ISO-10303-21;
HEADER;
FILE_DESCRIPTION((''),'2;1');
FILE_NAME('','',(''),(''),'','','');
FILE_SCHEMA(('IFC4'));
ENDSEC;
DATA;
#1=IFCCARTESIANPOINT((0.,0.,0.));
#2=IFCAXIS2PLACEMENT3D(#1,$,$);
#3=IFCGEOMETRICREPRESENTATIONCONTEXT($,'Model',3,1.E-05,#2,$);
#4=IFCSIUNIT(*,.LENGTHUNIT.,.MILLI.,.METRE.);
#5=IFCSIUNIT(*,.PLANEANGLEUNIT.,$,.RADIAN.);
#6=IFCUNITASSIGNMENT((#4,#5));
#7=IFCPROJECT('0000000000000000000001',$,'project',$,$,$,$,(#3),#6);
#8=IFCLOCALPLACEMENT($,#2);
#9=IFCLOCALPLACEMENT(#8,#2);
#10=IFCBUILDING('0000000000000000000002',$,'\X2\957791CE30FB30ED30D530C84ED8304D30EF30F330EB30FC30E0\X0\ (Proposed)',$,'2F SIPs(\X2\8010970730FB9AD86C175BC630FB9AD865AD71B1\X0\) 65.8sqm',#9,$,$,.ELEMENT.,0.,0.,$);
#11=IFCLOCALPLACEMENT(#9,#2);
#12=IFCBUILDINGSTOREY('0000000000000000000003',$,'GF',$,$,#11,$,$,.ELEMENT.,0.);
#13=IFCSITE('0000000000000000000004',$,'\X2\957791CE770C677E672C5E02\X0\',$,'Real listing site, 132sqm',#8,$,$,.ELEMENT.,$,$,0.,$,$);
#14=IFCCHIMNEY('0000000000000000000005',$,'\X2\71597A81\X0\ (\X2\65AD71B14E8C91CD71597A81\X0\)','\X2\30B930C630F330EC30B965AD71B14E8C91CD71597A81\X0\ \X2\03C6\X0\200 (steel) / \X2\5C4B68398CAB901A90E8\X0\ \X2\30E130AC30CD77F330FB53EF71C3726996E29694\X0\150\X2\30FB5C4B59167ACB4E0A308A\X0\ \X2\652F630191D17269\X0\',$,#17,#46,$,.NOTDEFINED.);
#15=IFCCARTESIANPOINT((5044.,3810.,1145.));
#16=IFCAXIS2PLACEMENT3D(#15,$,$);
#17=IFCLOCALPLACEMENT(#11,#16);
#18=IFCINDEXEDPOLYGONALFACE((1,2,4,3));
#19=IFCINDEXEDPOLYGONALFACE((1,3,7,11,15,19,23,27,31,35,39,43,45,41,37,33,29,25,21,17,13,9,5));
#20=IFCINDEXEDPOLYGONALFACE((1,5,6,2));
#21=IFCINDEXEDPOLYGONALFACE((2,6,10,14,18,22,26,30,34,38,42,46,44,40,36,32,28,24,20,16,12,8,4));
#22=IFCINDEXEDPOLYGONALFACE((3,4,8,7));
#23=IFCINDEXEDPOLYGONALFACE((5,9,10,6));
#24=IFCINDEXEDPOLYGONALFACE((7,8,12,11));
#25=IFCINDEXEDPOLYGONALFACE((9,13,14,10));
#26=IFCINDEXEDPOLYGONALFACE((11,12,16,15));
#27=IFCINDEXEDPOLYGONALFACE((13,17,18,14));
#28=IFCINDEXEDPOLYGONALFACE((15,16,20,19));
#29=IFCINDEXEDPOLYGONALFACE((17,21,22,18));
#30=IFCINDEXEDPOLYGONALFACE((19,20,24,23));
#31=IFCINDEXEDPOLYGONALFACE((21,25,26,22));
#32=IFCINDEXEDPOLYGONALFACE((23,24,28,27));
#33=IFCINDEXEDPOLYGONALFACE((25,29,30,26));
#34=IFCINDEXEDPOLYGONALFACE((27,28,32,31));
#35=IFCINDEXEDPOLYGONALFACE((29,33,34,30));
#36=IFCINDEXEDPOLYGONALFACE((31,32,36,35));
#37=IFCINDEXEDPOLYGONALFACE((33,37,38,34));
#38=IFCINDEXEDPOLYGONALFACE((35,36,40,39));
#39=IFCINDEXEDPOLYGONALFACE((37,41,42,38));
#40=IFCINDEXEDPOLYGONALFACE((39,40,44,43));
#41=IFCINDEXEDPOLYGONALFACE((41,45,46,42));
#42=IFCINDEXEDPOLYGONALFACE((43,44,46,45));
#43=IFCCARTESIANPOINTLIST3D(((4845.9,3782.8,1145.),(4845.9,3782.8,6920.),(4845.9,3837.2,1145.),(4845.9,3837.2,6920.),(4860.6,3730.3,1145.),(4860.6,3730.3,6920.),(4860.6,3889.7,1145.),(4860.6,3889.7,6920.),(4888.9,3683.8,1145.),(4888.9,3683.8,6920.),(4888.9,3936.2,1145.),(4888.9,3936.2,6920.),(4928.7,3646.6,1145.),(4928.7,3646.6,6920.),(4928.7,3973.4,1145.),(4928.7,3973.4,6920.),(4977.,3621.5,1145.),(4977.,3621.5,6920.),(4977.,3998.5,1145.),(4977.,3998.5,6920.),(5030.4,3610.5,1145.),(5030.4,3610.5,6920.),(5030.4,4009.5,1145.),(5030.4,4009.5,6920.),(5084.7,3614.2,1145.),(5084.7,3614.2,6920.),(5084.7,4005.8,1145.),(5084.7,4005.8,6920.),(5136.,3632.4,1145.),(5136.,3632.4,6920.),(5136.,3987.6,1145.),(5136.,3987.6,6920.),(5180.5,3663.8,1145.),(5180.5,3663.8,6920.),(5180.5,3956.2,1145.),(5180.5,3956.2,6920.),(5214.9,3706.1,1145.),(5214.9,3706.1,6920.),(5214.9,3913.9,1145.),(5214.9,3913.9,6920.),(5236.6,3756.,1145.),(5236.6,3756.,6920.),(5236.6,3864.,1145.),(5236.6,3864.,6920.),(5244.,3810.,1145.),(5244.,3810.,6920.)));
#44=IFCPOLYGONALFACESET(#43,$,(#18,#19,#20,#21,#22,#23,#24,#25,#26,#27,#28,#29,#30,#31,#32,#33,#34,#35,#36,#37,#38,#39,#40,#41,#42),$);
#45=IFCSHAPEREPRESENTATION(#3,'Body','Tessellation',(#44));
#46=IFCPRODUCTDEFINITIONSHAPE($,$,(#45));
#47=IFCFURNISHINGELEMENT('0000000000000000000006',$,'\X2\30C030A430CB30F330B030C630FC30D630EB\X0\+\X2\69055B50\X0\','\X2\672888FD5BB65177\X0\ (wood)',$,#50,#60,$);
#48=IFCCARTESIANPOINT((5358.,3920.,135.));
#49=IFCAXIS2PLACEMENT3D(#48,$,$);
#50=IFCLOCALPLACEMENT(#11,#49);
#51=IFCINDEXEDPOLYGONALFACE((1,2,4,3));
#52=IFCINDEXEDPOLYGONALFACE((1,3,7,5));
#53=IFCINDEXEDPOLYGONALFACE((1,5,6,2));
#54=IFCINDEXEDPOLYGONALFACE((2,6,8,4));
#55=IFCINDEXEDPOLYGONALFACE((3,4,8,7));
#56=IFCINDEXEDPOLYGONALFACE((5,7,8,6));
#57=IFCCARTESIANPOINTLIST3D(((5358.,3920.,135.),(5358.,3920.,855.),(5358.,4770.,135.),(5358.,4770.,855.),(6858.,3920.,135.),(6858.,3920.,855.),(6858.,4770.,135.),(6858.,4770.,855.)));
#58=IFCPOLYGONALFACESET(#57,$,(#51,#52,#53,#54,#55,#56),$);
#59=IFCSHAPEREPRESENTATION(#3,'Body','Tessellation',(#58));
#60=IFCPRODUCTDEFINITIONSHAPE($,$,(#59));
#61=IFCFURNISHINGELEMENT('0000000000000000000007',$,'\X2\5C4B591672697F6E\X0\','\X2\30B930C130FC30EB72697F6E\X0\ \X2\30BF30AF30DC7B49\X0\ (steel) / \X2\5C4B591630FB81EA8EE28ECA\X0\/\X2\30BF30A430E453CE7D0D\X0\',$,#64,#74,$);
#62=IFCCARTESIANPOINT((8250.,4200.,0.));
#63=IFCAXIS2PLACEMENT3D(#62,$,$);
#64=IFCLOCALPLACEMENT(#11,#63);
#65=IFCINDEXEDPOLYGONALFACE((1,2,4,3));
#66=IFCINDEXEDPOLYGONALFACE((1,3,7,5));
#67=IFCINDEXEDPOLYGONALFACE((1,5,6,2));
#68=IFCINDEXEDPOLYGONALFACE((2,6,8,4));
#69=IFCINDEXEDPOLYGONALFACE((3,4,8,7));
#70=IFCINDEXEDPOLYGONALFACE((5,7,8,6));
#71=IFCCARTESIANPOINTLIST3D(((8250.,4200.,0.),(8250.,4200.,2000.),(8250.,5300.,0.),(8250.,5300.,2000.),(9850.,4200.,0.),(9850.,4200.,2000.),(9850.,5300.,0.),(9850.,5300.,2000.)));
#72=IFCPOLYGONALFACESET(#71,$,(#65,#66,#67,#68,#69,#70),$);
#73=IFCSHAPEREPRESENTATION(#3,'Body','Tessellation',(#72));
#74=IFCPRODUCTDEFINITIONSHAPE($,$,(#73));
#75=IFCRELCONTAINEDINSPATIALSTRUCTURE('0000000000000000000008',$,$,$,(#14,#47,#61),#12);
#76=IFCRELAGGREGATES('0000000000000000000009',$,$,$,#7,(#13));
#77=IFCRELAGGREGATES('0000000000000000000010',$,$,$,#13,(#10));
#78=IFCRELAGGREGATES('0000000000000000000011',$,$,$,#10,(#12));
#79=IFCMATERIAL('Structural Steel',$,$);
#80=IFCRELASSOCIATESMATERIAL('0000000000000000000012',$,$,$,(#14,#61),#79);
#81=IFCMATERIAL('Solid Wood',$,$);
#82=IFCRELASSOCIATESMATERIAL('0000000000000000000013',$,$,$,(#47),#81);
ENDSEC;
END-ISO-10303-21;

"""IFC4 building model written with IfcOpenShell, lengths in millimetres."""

from ifc_helpers import new_model, si_unit, frame, frame_2d, origin, origin_2d, place, context, project, spatial, rectangle, circle, extrude, material, element, save


model = new_model("IFC4")

# Units and contexts
model_context = context("Model", 3, precision=1e-05, world=origin())
ifc_project = project(units=[si_unit("LENGTHUNIT", "METRE", prefix="MILLI"), si_unit("PLANEANGLEUNIT", "RADIAN")], contexts=[model_context])

# Site, building, storey
site_placement = place(None, origin())
site = spatial("IfcSite", under=ifc_project, at=site_placement, Name="長野県松本市", ObjectType="Real listing site, 132sqm", CompositionType="ELEMENT", RefElevation=0.0)
building_placement = place(site_placement, origin())
building = spatial("IfcBuilding", under=site, at=building_placement, Name="長野・ロフト付きワンルーム (Proposed)", ObjectType="2F SIPs(耐震・高気密・高断熱) 65.8sqm", CompositionType="ELEMENT", ElevationOfRefHeight=0.0, ElevationOfTerrain=0.0)
storey_placement = place(building_placement, origin())
storey = spatial("IfcBuildingStorey", under=building, at=storey_placement, Name="GF", CompositionType="ELEMENT", Elevation=0.0)

# Shared definitions
ifc_material_1 = material(Name="Solid Wood")

# Shared definitions
ifc_material_2 = material(Name="Structural Steel")

# Chimney
chimney_placement = place(storey_placement, frame((5044.0, 3810.0, 1145.0)))
element("IfcChimney", 1, at=chimney_placement, inside=storey, material=ifc_material_2, Name="煙突 (断熱二重煙突)", Description="ステンレス断熱二重煙突 φ200 (steel) / 屋根貫通部 メガネ石・可燃物離隔150・屋外立上り 支持金物", PredefinedType="NOTDEFINED", context=model_context, shape_type="SweptSolid", body=[
    extrude(circle(Radius=200.0, at=origin_2d()), frame((5044.0, 3810.0, 1145.0)), (0.0, 0.0, 1.0), 5775.0),
])

# Furnishing elements
furnishing_1_placement = place(storey_placement, frame((5358.0, 3920.0, 135.0)))
element("IfcFurnishingElement", 2, at=furnishing_1_placement, inside=storey, material=ifc_material_1, Name="ダイニングテーブル+椅子", Description="木製家具 (wood)", context=model_context, shape_type="SweptSolid", body=[
    extrude(rectangle(XDim=1500.0, YDim=850.0, at=frame_2d((750.0, 425.0))), frame((5358.0, 3920.0, 135.0)), (0.0, 0.0, 1.0), 720.0),
])
furnishing_2_placement = place(storey_placement, frame((8250.0, 4200.0, 0.0)))
element("IfcFurnishingElement", 3, at=furnishing_2_placement, inside=storey, material=ifc_material_2, Name="屋外物置", Description="スチール物置 タクボ等 (steel) / 屋外・自転車/タイヤ収納", context=model_context, shape_type="SweptSolid", body=[
    extrude(rectangle(XDim=1600.0, YDim=1100.0, at=frame_2d((800.0, 550.0))), frame((8250.0, 4200.0, 0.0)), (0.0, 0.0, 1.0), 2000.0),
])

save(model, "model.ifc")
